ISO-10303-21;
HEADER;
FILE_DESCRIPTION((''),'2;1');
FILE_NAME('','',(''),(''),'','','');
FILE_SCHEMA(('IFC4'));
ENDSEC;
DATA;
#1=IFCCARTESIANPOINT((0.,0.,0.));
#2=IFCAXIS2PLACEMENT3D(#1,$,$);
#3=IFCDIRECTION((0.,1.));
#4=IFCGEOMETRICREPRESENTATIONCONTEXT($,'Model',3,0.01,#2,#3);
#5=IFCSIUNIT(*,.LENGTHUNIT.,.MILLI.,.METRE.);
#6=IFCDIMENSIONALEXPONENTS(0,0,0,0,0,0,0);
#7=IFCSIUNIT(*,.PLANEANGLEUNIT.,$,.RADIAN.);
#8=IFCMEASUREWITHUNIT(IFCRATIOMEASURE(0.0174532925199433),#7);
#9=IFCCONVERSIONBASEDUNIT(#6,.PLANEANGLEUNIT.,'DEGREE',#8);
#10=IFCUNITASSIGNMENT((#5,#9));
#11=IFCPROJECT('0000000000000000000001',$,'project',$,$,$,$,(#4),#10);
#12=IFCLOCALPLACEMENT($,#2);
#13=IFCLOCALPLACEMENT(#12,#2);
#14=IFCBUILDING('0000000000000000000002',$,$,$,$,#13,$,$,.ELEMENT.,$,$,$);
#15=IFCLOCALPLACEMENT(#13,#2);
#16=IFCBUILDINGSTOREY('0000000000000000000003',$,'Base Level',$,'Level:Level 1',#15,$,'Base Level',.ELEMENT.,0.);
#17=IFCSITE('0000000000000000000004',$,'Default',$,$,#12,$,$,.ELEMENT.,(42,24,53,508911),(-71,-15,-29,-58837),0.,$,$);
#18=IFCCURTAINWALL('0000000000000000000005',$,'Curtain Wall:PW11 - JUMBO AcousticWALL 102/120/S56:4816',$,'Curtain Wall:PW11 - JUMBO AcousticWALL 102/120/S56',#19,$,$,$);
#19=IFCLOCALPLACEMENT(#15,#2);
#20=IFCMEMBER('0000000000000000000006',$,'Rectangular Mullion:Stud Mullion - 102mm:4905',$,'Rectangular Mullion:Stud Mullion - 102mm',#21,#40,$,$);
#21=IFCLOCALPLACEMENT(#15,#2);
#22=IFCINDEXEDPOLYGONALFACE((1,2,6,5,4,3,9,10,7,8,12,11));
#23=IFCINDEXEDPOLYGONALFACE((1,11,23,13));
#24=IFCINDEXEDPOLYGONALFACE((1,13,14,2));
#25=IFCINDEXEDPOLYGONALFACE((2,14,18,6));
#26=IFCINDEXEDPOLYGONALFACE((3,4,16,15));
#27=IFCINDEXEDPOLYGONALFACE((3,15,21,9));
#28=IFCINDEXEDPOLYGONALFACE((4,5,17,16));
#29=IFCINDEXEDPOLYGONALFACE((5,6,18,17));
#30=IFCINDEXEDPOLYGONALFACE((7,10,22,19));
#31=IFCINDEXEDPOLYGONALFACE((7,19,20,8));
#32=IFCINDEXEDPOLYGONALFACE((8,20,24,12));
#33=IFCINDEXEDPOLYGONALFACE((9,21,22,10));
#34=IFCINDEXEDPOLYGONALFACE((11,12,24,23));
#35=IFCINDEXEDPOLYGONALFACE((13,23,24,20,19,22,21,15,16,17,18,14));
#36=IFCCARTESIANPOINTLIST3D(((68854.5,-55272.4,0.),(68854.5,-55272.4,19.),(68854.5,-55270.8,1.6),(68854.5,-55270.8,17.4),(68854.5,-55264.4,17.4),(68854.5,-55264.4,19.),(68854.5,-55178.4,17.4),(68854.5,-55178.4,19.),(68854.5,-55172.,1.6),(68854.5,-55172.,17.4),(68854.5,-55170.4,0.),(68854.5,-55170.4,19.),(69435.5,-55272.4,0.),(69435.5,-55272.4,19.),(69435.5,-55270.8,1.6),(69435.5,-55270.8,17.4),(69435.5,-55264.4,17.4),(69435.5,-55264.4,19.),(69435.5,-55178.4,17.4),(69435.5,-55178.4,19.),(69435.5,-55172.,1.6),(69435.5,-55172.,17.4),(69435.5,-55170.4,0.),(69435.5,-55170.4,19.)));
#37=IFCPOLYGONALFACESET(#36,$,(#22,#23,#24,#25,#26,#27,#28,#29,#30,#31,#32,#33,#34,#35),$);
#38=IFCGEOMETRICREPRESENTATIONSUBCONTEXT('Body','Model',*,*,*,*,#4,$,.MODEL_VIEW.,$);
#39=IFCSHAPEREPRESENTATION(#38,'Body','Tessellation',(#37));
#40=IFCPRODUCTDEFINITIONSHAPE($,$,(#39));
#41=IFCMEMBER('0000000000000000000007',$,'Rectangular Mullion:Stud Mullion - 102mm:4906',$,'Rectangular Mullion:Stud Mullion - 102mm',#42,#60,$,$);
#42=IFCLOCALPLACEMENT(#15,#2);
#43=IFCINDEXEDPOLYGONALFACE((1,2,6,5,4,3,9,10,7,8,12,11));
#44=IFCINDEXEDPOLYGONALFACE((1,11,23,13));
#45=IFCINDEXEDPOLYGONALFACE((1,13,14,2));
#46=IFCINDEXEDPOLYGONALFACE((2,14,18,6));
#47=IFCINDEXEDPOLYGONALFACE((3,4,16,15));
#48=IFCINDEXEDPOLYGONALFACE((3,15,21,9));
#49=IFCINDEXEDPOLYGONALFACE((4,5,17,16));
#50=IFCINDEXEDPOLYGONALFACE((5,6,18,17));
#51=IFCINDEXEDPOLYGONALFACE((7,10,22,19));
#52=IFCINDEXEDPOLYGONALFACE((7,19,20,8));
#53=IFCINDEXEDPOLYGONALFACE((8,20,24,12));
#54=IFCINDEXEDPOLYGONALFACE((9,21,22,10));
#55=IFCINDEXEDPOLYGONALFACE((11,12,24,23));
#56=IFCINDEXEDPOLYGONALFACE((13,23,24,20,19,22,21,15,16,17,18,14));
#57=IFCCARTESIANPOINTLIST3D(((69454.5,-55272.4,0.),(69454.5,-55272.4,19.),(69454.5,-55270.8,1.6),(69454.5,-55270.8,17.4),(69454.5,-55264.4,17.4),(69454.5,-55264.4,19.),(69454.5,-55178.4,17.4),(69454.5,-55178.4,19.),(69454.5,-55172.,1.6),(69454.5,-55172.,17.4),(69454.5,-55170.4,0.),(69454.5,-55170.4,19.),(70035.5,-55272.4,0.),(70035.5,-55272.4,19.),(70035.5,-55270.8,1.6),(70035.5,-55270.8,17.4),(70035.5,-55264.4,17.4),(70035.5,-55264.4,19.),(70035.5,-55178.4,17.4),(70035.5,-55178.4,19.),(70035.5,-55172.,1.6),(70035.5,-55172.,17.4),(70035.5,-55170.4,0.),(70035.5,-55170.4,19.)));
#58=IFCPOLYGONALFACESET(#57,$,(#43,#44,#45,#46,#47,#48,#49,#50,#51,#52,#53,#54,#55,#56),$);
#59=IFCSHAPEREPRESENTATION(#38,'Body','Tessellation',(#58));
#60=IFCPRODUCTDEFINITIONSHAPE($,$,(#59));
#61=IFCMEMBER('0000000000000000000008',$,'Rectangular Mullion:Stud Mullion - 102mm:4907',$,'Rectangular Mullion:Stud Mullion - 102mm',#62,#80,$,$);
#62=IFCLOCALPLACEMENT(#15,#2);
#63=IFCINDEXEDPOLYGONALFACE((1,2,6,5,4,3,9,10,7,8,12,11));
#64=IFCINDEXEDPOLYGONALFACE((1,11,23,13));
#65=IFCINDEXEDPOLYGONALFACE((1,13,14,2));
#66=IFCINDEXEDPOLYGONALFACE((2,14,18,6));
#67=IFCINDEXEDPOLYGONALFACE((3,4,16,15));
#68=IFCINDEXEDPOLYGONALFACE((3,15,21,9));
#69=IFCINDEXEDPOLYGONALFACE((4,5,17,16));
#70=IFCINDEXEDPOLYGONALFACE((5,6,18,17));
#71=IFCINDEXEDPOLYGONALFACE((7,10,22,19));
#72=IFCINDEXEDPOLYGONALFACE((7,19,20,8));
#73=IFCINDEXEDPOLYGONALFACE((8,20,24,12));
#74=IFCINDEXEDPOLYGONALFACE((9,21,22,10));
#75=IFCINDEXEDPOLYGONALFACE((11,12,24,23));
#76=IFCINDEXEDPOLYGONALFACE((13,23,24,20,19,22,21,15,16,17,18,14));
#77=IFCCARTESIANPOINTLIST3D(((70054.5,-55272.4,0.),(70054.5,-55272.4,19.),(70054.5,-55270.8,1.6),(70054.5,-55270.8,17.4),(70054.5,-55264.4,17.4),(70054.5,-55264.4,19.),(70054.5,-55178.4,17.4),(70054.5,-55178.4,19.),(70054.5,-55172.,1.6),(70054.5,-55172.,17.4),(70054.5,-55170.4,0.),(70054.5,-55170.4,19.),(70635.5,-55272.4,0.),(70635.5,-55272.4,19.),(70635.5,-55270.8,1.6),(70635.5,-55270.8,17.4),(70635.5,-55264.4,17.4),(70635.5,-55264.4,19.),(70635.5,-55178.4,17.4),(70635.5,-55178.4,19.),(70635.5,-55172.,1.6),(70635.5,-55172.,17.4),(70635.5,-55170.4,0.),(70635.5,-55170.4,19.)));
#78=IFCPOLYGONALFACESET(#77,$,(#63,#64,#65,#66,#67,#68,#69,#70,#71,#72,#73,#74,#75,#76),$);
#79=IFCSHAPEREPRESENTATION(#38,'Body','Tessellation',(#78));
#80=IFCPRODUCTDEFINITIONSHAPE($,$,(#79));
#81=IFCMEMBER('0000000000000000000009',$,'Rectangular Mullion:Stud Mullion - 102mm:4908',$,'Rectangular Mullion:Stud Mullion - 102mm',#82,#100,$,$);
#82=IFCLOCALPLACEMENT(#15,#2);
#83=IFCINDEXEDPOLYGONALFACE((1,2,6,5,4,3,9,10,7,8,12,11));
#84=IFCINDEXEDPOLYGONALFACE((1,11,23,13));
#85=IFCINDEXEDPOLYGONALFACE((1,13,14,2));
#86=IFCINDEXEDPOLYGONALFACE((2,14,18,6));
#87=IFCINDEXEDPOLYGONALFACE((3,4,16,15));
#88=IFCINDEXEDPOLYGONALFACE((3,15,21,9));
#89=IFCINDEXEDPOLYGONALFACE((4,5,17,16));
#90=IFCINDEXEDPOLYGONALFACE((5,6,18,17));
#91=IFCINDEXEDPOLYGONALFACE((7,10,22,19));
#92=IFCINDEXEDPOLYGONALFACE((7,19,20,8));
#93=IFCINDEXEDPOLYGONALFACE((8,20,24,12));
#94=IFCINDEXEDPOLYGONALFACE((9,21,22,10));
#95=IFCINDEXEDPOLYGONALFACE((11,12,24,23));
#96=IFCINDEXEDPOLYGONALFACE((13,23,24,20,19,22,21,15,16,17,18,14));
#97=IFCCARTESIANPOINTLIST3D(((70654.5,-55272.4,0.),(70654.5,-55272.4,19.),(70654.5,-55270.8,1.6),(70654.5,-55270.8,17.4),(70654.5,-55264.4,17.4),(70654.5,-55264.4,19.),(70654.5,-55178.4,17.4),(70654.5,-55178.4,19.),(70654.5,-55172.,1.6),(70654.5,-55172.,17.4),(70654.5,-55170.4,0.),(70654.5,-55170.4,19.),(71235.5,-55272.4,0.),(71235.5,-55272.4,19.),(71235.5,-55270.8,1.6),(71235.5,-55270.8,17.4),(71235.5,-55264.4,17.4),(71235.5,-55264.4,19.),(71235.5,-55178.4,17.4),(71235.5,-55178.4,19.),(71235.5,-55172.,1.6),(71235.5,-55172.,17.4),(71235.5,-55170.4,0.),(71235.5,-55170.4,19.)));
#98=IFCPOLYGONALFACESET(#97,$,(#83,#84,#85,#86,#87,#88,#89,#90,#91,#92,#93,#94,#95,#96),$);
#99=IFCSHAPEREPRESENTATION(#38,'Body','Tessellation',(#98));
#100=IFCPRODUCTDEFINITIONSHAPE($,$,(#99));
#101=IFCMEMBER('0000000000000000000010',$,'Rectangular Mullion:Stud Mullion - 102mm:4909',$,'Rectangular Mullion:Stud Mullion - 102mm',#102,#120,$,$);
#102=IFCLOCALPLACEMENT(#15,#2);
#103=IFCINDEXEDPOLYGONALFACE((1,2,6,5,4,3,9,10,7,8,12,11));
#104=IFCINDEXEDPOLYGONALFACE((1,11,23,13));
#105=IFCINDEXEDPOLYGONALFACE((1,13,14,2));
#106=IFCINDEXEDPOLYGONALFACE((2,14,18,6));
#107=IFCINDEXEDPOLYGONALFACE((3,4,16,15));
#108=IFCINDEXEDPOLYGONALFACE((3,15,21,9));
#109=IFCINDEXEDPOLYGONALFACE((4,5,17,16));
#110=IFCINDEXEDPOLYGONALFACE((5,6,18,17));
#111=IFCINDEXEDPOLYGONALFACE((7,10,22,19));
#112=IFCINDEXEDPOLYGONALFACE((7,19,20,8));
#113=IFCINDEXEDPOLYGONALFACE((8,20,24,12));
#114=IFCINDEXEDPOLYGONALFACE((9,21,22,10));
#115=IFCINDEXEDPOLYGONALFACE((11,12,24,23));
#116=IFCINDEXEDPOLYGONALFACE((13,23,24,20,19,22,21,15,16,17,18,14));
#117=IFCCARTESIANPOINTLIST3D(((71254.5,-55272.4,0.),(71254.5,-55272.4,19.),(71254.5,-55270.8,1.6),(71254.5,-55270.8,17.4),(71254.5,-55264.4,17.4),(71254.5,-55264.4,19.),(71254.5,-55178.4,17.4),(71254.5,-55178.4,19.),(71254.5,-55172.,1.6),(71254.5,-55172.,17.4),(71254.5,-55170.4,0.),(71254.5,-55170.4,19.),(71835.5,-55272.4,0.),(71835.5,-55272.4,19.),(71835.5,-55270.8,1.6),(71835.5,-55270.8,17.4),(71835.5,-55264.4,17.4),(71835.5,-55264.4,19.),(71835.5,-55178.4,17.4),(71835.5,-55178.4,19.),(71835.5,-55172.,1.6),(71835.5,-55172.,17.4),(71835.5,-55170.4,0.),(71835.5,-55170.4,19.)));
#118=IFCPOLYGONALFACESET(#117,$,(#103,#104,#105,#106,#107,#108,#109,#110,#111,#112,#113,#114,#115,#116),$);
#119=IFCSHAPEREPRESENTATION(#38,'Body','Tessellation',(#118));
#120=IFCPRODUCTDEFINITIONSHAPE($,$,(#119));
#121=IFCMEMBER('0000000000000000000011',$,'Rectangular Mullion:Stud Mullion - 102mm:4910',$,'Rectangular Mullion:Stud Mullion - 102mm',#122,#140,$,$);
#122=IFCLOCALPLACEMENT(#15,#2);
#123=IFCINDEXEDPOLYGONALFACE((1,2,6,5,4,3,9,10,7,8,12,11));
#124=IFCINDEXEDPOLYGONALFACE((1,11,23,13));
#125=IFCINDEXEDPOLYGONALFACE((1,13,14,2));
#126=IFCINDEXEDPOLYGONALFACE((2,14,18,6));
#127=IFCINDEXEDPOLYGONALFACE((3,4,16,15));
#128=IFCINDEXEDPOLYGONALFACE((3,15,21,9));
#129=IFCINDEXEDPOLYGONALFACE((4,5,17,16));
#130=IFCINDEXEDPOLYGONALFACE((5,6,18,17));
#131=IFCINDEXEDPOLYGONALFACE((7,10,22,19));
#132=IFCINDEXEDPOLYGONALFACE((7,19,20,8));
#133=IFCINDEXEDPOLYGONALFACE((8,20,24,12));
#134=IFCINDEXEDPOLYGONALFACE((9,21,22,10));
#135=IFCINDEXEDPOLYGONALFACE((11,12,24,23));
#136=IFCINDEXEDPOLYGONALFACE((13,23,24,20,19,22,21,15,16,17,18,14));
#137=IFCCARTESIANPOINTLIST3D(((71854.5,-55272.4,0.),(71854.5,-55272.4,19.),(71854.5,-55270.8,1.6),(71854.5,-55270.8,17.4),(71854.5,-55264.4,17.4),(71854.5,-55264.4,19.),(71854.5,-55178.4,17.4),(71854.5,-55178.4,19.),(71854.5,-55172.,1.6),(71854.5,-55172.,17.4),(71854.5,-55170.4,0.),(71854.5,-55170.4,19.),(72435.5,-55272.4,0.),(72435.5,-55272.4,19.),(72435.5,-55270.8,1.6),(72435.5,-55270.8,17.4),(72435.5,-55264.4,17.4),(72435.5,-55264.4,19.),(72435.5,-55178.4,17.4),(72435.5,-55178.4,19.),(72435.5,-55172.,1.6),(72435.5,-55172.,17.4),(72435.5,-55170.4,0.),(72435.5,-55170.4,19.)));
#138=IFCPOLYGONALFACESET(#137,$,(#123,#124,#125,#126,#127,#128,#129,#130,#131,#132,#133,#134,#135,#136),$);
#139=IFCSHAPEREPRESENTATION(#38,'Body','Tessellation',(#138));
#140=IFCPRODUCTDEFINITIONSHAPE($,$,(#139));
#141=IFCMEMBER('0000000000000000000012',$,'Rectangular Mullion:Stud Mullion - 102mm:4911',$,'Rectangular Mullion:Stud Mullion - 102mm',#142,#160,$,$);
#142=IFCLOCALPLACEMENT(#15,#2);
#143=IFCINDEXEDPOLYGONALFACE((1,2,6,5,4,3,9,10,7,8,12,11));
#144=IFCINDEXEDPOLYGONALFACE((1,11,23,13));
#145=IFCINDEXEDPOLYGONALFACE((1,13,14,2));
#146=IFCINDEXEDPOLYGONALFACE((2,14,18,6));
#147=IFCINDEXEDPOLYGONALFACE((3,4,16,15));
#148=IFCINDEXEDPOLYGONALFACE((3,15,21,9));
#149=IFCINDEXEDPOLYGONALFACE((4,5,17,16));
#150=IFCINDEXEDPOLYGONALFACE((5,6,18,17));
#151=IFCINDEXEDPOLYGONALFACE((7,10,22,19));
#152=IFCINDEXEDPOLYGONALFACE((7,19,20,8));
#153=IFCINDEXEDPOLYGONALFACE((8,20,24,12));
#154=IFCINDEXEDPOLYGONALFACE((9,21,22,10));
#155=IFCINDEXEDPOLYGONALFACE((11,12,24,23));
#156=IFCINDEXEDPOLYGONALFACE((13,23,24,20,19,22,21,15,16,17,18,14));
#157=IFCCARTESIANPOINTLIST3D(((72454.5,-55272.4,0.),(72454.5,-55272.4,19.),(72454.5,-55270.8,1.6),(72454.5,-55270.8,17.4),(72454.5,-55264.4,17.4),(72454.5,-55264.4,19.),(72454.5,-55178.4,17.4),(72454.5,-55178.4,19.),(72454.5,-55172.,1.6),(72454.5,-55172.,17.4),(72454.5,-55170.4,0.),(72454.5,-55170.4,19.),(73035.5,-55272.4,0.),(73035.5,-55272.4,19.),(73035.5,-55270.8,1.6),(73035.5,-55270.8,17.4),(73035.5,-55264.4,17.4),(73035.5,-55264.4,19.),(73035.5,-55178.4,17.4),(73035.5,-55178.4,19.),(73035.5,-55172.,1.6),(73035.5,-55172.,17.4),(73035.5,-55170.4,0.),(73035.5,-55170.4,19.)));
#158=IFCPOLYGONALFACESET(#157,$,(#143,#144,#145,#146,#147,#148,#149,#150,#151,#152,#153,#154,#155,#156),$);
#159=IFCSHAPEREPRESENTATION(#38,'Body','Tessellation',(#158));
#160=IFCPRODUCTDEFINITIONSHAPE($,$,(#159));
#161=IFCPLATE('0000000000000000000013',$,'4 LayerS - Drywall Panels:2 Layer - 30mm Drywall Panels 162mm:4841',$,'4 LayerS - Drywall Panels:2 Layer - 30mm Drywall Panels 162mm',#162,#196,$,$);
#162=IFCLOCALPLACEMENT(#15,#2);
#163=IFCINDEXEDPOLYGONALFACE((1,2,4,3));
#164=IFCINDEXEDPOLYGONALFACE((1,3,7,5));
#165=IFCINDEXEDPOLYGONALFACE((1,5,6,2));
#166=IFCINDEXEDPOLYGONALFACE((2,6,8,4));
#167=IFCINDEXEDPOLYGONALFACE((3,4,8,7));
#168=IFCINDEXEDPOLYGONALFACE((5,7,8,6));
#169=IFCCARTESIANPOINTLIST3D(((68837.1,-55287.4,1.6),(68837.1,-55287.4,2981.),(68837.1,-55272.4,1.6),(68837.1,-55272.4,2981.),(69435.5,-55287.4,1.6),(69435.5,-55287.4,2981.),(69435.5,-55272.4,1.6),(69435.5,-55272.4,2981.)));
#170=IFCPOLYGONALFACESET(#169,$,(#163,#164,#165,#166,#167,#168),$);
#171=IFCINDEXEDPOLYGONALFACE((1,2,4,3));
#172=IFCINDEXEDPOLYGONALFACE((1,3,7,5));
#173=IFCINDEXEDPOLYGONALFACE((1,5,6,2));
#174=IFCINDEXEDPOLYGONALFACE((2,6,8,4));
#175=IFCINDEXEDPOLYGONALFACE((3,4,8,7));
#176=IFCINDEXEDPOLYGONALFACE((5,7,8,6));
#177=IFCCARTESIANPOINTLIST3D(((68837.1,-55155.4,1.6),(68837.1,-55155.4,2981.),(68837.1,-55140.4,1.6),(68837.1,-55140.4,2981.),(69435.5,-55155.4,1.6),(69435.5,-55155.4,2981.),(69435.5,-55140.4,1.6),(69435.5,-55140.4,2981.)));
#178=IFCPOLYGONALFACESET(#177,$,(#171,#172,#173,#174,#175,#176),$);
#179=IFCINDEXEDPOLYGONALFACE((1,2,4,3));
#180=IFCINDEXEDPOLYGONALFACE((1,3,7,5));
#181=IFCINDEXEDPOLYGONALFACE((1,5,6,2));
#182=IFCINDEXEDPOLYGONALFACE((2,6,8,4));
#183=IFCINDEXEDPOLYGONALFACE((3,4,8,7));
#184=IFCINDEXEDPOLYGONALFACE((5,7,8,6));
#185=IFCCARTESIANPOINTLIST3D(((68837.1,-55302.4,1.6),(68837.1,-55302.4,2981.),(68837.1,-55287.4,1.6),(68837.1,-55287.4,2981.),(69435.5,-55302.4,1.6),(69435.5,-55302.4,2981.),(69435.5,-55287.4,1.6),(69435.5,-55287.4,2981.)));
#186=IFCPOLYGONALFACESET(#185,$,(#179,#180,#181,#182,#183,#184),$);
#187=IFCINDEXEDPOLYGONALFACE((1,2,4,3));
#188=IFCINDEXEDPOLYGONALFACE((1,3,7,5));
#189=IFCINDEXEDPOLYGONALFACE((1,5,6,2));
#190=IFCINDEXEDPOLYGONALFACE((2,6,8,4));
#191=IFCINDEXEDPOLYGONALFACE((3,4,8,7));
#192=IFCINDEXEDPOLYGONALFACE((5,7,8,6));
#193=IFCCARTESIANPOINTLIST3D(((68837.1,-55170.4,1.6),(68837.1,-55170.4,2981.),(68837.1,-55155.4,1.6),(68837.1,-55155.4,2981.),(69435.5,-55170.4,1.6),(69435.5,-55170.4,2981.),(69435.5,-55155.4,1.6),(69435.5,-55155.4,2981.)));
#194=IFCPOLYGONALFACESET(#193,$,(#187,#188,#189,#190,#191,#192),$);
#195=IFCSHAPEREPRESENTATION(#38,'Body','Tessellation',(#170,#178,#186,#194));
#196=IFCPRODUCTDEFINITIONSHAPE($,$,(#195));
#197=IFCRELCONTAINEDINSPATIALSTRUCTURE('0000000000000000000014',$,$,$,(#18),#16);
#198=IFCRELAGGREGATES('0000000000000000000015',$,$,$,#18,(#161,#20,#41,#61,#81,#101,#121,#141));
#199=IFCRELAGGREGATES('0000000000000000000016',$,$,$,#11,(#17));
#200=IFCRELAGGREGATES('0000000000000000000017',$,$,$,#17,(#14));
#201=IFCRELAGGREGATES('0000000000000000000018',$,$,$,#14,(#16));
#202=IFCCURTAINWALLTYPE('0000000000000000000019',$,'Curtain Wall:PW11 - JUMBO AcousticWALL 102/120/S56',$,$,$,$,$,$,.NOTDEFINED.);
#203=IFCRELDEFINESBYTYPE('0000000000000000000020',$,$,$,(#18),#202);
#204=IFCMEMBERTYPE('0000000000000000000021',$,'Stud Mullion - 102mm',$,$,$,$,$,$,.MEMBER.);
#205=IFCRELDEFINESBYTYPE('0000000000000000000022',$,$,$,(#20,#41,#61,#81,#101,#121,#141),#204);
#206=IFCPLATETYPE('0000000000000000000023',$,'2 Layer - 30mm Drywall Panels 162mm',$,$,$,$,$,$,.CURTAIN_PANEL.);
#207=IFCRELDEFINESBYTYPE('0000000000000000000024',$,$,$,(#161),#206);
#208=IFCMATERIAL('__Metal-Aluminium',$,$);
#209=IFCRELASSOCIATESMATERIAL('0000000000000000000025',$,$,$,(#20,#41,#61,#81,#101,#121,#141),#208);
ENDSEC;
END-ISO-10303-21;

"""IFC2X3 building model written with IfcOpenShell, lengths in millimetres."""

from ifc_helpers import new_model, entity, si_unit, converted_unit, direction, frame, frame_2d, origin, origin_2d_with_axis, place, context, subcontext, project, spatial, polyline, rectangle, outline, extrude, source, transform, mapped, material, type_object, type_shapes, element, aggregate, save


model = new_model("IFC2X3")

# Units and contexts
model_context = context("Model", 3, precision=0.01, world=origin(), true_north=direction((0.0, 1.0)))
body_context = subcontext(model_context, "Body", "Model", "MODEL_VIEW")
ifc_project = project(units=[si_unit("LENGTHUNIT", "METRE", prefix="MILLI"), converted_unit("PLANEANGLEUNIT", "DEGREE", entity("IfcRatioMeasure", 0.0174532925199433), si_unit("PLANEANGLEUNIT", "RADIAN"), dimensions=[0, 0, 0, 0, 0, 0, 0])], contexts=[model_context])

# Site, building, storey
site_placement = place(None, origin())
site = spatial("IfcSite", under=ifc_project, at=site_placement, Name="Default", CompositionType="ELEMENT", RefLatitude=(42, 24, 53, 508911), RefLongitude=(-71, -15, -29, -58837), RefElevation=0.0)
building_placement = place(site_placement, origin())
building = spatial("IfcBuilding", under=site, at=building_placement, CompositionType="ELEMENT")
storey_placement = place(building_placement, origin())
storey = spatial("IfcBuildingStorey", under=building, at=storey_placement, Name="Base Level", ObjectType="Level:Level 1", LongName="Base Level", CompositionType="ELEMENT", Elevation=0.0)

# Curtain wall, members, plate
curtain_wall_type = type_object("IfcCurtainWallType", Name="Curtain Wall:PW11 - JUMBO AcousticWALL 102/120/S56", PredefinedType="NOTDEFINED")
curtain_wall_placement = place(building_placement, origin())
curtain_wall = element("IfcCurtainWall", 1, at=curtain_wall_placement, inside=storey, type_object=curtain_wall_type, Name="Curtain Wall:PW11 - JUMBO AcousticWALL 102/120/S56:4816", ObjectType="Curtain Wall:PW11 - JUMBO AcousticWALL 102/120/S56")
ifc_material = material(Name="__Metal-Aluminium")
member_type_1 = type_object("IfcMemberType", Name="Stud Mullion - 102mm", PredefinedType="MEMBER")
shared_shape_1 = source(origin(), body_context, "Body", "SweptSolid", [
    extrude(outline(polyline([(43.0, -6.6), (51.0, -6.6), (51.0, 12.4), (-51.0, 12.4), (-51.0, -6.6), (-43.0, -6.6), (-43.0, -5.0), (-49.4, -5.0), (-49.4, 10.8), (49.4, 10.8), (49.4, -5.0), (43.0, -5.0), (43.0, -6.6)])), frame((-12.4, 0.0, -581.0), z_axis=(0.0, 0.0, 1.0), x_axis=(0.0, -1.0, 0.0)), (0.0, 0.0, 1.0), 581.0),
])
type_shapes(member_type_1, [shared_shape_1])
member_1_placement = place(building_placement, frame((68854.5, -55221.4, 0.0), z_axis=(-1.0, 0.0, 0.0), x_axis=(0.0, 0.0, -1.0)))
member_1 = element("IfcMember", 2, at=member_1_placement, type_object=member_type_1, material=ifc_material, Name="Rectangular Mullion:Stud Mullion - 102mm:4905", ObjectType="Rectangular Mullion:Stud Mullion - 102mm", context=body_context, shape_type="MappedRepresentation", body=[
    mapped(shared_shape_1, transform((0.0, 0.0, 0.0), scale=1.0)),
])
member_2_placement = place(building_placement, frame((69454.5, -55221.4, 0.0), z_axis=(-1.0, 0.0, 0.0), x_axis=(0.0, 0.0, -1.0)))
member_2 = element("IfcMember", 3, at=member_2_placement, type_object=member_type_1, material=ifc_material, Name="Rectangular Mullion:Stud Mullion - 102mm:4906", ObjectType="Rectangular Mullion:Stud Mullion - 102mm", context=body_context, shape_type="MappedRepresentation", body=[
    mapped(shared_shape_1, transform((0.0, 0.0, 0.0), scale=1.0)),
])
member_3_placement = place(building_placement, frame((70054.5, -55221.4, 0.0), z_axis=(-1.0, 0.0, 0.0), x_axis=(0.0, 0.0, -1.0)))
member_3 = element("IfcMember", 4, at=member_3_placement, type_object=member_type_1, material=ifc_material, Name="Rectangular Mullion:Stud Mullion - 102mm:4907", ObjectType="Rectangular Mullion:Stud Mullion - 102mm", context=body_context, shape_type="MappedRepresentation", body=[
    mapped(shared_shape_1, transform((0.0, 0.0, 0.0), scale=1.0)),
])
member_4_placement = place(building_placement, frame((70654.5, -55221.4, 0.0), z_axis=(-1.0, 0.0, 0.0), x_axis=(0.0, 0.0, -1.0)))
member_4 = element("IfcMember", 5, at=member_4_placement, type_object=member_type_1, material=ifc_material, Name="Rectangular Mullion:Stud Mullion - 102mm:4908", ObjectType="Rectangular Mullion:Stud Mullion - 102mm", context=body_context, shape_type="MappedRepresentation", body=[
    mapped(shared_shape_1, transform((0.0, 0.0, 0.0), scale=1.0)),
])
member_5_placement = place(building_placement, frame((71254.5, -55221.4, 0.0), z_axis=(-1.0, 0.0, 0.0), x_axis=(0.0, 0.0, -1.0)))
member_5 = element("IfcMember", 6, at=member_5_placement, type_object=member_type_1, material=ifc_material, Name="Rectangular Mullion:Stud Mullion - 102mm:4909", ObjectType="Rectangular Mullion:Stud Mullion - 102mm", context=body_context, shape_type="MappedRepresentation", body=[
    mapped(shared_shape_1, transform((0.0, 0.0, 0.0), scale=1.0)),
])
member_6_placement = place(building_placement, frame((71854.5, -55221.4, 0.0), z_axis=(-1.0, 0.0, 0.0), x_axis=(0.0, 0.0, -1.0)))
member_6 = element("IfcMember", 7, at=member_6_placement, type_object=member_type_1, material=ifc_material, Name="Rectangular Mullion:Stud Mullion - 102mm:4910", ObjectType="Rectangular Mullion:Stud Mullion - 102mm", context=body_context, shape_type="MappedRepresentation", body=[
    mapped(shared_shape_1, transform((0.0, 0.0, 0.0), scale=1.0)),
])
member_7_placement = place(building_placement, frame((72454.5, -55221.4, 0.0), z_axis=(-1.0, 0.0, 0.0), x_axis=(0.0, 0.0, -1.0)))
member_7 = element("IfcMember", 8, at=member_7_placement, type_object=member_type_1, material=ifc_material, Name="Rectangular Mullion:Stud Mullion - 102mm:4911", ObjectType="Rectangular Mullion:Stud Mullion - 102mm", context=body_context, shape_type="MappedRepresentation", body=[
    mapped(shared_shape_1, transform((0.0, 0.0, 0.0), scale=1.0)),
])
plate_type = type_object("IfcPlateType", Name="2 Layer - 30mm Drywall Panels 162mm", PredefinedType="CURTAIN_PANEL")
shared_shape_2 = source(origin(), body_context, "Body", "SweptSolid", [
    extrude(rectangle(XDim=15.0, YDim=598.4, at=origin_2d_with_axis()), frame((0.0, -58.5, 0.0), z_axis=(0.0, 0.0, 1.0), x_axis=(0.0, 1.0, 0.0)), (0.0, 0.0, 1.0), 2979.4),
    extrude(rectangle(XDim=15.0, YDim=598.4, at=frame_2d((0.0, 0.0), x_axis=(1.0, 0.0))), frame((0.0, 73.5, 0.0), z_axis=(0.0, 0.0, 1.0), x_axis=(0.0, 1.0, 0.0)), (0.0, 0.0, 1.0), 2979.4),
    extrude(rectangle(XDim=598.4, YDim=15.0, at=origin_2d_with_axis()), frame((0.0, -73.5, 0.0), z_axis=(0.0, 0.0, 1.0), x_axis=(-1.0, 0.0, 0.0)), (0.0, 0.0, 1.0), 2979.4),
    extrude(rectangle(XDim=15.0, YDim=598.4, at=frame_2d((0.0, 0.0), x_axis=(1.0, 0.0))), frame((0.0, 58.5, 0.0), z_axis=(0.0, 0.0, 1.0), x_axis=(0.0, 1.0, 0.0)), (0.0, 0.0, 1.0), 2979.4),
])
type_shapes(plate_type, [shared_shape_2])
plate_1_placement = place(curtain_wall_placement, frame((69136.3, -55221.4, 1.6)))
plate_1 = element("IfcPlate", 9, at=plate_1_placement, type_object=plate_type, Name="4 LayerS - Drywall Panels:2 Layer - 30mm Drywall Panels 162mm:4841", ObjectType="4 LayerS - Drywall Panels:2 Layer - 30mm Drywall Panels 162mm", context=body_context, shape_type="MappedRepresentation", body=[
    mapped(shared_shape_2, transform((0.0, 0.0, 0.0), scale=1.0)),
])
aggregate(curtain_wall, [plate_1, member_1, member_2, member_3, member_4, member_5, member_6, member_7])

save(model, "model.ifc")
